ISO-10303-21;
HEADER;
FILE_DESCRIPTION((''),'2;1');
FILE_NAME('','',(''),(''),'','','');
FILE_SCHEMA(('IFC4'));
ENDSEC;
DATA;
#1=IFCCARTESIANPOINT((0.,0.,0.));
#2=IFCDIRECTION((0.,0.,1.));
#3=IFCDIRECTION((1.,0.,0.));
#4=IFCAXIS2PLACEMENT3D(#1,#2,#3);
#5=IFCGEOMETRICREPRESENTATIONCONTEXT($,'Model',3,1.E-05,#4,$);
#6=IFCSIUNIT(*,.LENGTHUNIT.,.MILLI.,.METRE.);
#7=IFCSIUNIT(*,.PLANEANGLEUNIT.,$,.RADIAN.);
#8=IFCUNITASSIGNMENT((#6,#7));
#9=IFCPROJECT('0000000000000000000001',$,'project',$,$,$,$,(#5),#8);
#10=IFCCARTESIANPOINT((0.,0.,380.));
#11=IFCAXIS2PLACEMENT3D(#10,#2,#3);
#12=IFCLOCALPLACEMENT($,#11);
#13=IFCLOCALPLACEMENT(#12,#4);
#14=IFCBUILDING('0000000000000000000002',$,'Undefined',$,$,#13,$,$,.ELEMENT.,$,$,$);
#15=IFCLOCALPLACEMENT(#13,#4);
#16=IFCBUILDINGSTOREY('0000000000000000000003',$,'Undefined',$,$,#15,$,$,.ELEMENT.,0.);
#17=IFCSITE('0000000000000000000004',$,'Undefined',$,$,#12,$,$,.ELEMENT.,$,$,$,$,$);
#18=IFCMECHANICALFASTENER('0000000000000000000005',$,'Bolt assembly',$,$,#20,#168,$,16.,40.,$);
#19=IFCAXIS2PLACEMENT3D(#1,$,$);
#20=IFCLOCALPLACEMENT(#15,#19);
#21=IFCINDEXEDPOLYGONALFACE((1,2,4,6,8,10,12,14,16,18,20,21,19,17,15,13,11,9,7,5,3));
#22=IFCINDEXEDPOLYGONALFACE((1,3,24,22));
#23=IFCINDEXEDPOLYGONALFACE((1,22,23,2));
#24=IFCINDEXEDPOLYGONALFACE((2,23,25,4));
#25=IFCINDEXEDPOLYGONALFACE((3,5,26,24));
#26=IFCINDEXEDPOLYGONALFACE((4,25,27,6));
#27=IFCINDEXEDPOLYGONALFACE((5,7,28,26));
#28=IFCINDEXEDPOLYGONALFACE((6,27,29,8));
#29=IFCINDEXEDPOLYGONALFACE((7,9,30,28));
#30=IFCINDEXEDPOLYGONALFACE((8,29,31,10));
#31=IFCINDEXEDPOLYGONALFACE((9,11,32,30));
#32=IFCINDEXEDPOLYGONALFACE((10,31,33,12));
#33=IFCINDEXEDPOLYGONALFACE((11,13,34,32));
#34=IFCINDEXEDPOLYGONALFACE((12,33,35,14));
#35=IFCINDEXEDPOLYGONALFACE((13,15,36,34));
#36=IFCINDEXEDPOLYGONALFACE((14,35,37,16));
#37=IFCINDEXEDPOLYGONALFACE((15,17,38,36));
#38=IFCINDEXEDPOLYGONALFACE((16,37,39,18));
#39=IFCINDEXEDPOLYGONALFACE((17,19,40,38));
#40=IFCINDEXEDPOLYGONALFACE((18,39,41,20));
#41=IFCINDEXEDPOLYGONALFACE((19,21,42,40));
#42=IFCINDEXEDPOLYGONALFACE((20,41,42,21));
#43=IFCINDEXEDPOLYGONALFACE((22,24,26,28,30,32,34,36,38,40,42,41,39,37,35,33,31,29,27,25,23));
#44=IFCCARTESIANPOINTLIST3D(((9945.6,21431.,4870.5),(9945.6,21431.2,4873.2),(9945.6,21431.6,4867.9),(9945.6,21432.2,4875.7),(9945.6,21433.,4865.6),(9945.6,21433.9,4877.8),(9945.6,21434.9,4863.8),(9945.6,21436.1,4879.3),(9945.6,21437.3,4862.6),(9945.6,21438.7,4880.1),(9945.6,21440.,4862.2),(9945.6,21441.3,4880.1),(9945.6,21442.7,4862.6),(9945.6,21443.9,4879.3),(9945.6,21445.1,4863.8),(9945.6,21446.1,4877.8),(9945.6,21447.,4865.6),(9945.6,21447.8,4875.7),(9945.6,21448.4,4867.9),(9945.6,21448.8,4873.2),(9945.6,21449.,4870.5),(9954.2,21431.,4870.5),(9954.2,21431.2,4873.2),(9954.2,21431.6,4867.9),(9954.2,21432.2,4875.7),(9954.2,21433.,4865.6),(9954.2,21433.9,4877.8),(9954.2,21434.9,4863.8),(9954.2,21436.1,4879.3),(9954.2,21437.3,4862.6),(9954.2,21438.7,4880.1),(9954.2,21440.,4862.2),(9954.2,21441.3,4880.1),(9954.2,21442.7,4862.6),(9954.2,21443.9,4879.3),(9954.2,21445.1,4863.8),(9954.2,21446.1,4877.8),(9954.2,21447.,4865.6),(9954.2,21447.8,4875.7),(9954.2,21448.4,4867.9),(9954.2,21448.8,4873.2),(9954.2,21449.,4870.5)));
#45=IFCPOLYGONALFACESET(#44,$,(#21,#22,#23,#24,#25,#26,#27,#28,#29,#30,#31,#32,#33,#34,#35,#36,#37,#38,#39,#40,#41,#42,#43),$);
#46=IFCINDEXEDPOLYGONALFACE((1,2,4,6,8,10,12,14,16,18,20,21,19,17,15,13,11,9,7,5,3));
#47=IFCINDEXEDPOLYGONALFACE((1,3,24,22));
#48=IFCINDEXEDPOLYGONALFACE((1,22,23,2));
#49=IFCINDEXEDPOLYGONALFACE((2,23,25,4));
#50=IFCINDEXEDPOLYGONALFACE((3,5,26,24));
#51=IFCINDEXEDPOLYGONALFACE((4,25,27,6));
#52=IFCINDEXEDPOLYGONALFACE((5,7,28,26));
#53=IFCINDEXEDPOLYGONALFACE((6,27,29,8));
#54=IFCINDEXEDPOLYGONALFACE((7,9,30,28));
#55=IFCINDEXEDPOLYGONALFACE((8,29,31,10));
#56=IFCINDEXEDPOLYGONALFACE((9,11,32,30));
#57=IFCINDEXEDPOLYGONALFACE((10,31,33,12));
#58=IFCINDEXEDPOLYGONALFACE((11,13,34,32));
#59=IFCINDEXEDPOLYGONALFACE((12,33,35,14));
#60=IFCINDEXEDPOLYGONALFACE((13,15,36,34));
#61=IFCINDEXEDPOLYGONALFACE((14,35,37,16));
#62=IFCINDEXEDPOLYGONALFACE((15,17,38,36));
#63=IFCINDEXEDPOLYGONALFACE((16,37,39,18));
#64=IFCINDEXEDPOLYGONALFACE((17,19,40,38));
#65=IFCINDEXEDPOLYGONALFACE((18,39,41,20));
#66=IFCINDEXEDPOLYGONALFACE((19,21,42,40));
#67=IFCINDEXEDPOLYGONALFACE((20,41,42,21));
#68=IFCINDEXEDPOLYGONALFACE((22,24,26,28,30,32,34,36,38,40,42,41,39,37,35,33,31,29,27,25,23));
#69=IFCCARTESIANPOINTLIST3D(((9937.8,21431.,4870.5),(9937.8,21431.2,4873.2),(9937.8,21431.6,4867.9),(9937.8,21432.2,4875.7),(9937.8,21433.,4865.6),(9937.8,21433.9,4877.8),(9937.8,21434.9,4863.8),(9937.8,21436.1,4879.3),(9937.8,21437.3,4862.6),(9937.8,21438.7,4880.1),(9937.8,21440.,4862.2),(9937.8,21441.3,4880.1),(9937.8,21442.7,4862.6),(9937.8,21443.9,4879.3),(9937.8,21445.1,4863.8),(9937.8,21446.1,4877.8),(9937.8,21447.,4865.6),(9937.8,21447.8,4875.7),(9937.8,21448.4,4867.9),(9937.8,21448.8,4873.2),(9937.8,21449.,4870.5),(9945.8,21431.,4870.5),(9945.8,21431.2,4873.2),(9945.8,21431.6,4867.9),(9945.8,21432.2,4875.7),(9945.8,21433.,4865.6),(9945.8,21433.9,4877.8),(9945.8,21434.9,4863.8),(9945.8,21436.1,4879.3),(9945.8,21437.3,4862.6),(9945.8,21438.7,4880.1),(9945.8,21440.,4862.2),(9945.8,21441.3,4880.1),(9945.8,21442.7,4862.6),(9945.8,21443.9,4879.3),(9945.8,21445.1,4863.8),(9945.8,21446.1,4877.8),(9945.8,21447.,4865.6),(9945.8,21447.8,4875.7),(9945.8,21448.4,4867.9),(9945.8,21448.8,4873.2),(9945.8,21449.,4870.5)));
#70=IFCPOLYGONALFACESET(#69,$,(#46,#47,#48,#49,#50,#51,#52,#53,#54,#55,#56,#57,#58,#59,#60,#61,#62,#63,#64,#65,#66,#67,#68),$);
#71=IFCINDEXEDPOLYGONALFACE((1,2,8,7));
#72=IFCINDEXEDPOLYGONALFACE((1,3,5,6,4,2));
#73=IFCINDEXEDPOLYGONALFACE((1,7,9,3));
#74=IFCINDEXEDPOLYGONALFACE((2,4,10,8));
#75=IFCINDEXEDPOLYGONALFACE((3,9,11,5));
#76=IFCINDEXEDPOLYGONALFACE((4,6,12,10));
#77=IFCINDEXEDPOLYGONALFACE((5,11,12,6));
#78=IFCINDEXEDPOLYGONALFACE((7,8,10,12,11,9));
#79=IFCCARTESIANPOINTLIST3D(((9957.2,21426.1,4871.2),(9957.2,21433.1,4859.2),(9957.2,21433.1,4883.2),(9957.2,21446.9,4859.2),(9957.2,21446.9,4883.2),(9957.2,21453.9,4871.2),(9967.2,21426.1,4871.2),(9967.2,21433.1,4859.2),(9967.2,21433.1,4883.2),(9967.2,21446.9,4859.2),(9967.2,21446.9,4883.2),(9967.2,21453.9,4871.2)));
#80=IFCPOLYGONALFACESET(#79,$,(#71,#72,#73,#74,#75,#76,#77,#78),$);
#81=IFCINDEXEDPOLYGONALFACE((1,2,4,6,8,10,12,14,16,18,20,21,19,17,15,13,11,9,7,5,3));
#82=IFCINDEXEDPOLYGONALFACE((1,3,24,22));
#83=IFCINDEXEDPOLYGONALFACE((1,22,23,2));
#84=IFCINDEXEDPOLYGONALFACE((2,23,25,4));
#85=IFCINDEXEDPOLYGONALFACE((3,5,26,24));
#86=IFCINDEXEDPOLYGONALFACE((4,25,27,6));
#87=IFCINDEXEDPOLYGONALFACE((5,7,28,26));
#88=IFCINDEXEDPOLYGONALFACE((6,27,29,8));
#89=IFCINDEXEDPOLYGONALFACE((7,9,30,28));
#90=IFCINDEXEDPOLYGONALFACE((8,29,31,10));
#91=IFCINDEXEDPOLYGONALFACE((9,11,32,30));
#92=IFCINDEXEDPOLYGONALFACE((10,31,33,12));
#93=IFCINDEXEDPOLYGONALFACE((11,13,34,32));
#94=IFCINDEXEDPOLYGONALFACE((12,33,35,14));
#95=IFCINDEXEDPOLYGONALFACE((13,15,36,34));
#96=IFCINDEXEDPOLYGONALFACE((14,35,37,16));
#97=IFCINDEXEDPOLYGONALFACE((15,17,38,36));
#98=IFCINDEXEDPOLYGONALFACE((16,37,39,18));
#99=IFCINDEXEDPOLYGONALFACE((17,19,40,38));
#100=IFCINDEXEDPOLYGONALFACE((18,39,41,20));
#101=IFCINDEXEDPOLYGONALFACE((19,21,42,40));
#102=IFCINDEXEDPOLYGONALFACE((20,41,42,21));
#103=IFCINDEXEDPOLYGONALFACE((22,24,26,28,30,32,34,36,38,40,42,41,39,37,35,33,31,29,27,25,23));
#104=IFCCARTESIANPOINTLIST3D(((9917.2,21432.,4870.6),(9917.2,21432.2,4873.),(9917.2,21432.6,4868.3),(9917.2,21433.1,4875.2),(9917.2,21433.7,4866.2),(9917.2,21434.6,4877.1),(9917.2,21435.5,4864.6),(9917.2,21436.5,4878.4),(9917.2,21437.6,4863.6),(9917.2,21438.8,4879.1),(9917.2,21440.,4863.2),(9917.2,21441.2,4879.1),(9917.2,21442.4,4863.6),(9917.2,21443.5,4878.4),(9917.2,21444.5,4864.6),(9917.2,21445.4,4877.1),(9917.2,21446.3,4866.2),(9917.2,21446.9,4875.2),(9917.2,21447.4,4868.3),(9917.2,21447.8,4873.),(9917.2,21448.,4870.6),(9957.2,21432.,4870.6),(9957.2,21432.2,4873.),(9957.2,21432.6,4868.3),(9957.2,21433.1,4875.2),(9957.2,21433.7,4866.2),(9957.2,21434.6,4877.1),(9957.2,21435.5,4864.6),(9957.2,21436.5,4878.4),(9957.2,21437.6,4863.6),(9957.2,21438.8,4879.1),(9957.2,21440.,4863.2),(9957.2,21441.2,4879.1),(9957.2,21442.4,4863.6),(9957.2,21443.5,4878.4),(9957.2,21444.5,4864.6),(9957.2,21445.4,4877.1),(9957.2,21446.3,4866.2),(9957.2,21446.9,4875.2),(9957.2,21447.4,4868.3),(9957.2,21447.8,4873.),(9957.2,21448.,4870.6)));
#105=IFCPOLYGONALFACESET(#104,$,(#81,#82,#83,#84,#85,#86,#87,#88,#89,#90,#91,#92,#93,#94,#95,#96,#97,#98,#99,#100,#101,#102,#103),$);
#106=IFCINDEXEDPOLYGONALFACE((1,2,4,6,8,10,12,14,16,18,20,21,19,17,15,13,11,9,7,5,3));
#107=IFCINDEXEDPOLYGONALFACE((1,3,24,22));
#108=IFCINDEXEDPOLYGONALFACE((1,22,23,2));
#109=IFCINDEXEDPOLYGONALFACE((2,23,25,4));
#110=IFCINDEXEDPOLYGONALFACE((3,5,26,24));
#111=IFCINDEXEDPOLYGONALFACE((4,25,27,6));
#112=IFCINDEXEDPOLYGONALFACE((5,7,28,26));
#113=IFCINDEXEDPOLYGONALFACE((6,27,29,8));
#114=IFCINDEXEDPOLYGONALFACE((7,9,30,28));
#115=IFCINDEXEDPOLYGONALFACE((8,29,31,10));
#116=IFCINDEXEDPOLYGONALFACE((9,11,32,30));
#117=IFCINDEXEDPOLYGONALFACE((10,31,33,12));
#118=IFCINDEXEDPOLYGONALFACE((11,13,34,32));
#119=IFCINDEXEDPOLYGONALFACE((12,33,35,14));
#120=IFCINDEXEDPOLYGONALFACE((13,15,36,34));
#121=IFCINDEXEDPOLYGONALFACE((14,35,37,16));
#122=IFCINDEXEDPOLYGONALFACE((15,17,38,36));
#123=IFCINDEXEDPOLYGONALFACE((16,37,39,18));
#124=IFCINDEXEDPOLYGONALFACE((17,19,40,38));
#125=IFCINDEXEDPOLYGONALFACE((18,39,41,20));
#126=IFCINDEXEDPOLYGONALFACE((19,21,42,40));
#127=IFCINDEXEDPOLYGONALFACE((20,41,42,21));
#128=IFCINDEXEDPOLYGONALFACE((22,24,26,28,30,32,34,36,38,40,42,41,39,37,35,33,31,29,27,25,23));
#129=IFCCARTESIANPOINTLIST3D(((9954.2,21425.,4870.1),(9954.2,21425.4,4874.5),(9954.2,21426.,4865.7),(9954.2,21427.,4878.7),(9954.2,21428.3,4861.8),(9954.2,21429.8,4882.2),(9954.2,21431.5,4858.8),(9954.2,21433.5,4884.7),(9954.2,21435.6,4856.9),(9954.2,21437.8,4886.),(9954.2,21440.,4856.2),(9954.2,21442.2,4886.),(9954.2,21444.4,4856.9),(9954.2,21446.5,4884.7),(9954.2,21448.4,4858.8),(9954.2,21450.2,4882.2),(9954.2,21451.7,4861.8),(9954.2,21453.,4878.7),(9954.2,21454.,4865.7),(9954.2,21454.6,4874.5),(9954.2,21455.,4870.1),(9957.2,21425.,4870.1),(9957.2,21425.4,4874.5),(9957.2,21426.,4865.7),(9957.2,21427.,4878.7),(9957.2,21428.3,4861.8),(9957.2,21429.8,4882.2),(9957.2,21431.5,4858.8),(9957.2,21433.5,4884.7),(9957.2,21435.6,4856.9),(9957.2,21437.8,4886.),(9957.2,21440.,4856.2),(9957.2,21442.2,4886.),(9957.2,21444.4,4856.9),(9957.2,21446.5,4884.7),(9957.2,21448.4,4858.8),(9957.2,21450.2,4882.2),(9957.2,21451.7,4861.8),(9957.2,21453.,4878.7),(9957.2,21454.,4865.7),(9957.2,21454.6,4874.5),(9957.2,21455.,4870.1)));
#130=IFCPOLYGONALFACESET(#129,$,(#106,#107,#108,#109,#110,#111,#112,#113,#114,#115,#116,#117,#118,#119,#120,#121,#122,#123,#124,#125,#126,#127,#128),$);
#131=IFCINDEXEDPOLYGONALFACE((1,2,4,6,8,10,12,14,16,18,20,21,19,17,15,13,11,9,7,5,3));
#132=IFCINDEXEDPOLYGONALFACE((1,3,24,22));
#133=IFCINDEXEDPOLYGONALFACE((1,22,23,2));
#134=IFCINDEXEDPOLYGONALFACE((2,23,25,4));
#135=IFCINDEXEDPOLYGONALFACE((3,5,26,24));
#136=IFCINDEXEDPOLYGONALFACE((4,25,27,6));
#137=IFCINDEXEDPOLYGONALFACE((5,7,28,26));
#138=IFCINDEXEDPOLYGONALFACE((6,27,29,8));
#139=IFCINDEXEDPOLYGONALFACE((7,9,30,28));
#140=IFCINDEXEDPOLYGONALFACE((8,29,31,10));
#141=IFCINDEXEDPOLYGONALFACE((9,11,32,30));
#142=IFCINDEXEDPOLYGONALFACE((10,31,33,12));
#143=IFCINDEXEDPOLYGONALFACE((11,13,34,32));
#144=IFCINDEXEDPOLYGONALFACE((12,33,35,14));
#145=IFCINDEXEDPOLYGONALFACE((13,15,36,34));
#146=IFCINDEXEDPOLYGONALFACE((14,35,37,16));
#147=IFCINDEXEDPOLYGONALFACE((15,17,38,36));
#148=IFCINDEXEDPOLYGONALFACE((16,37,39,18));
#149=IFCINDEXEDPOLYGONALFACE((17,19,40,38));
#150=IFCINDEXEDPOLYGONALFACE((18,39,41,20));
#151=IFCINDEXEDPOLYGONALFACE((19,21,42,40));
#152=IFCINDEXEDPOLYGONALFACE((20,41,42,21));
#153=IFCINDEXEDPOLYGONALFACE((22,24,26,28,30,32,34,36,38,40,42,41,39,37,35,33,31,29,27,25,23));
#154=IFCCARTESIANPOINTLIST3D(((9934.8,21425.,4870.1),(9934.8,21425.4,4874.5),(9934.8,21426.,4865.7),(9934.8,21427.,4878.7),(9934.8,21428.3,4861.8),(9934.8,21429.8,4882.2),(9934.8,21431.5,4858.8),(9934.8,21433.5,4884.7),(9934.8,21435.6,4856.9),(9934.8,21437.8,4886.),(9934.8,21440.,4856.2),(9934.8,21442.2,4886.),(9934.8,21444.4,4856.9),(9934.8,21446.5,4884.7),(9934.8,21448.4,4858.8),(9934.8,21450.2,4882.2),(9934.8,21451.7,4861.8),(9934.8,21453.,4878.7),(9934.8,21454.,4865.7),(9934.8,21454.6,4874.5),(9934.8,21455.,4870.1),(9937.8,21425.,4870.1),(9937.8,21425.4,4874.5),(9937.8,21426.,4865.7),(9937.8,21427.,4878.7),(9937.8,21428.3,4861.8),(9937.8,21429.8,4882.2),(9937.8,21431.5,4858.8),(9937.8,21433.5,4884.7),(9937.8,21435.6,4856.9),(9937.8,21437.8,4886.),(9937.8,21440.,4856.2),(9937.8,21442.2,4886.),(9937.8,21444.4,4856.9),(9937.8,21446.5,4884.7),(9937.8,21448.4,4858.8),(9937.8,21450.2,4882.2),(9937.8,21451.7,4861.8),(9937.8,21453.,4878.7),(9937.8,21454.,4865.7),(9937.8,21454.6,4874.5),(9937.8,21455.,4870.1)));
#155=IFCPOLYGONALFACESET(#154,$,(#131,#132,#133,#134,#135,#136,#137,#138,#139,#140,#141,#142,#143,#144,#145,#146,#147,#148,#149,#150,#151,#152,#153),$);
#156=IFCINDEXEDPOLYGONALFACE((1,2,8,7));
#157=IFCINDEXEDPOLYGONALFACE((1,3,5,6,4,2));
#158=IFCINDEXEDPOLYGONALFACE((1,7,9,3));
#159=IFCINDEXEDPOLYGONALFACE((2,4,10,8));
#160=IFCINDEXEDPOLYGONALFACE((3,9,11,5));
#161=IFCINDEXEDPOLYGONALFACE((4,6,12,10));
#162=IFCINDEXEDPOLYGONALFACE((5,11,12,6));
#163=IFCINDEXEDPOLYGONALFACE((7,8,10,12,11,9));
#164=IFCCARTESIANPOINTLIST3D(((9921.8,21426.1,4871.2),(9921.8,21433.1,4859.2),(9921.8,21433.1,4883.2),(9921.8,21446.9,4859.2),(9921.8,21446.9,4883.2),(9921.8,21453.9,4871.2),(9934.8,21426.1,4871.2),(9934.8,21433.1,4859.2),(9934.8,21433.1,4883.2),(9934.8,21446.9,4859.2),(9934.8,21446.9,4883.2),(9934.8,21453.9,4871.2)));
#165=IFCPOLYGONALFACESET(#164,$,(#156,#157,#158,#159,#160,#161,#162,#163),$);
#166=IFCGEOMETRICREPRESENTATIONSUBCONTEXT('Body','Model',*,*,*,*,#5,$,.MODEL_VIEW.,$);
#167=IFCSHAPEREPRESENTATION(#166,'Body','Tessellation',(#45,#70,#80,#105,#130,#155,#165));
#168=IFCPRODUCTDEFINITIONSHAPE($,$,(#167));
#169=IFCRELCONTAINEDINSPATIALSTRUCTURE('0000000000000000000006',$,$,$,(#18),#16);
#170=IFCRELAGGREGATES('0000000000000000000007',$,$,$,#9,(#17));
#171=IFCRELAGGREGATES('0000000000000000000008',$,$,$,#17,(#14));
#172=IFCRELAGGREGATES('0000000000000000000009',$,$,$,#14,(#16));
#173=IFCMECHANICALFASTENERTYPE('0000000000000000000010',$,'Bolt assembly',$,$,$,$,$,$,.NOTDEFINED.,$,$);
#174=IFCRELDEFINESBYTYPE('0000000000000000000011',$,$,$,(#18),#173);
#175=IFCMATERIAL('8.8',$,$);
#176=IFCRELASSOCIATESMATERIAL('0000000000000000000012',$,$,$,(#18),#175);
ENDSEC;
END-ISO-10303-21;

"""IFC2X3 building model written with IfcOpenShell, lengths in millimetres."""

from ifc_helpers import new_model, si_unit, frame, origin_with_axes, origin_2d_with_axis, place, context, subcontext, project, spatial, polyline, circle, outline, extrude, source, transform, mapped, material, type_object, element, save


model = new_model("IFC2X3")

# Units and contexts
model_context = context("Model", 3, precision=1e-05, world=origin_with_axes())
body_context = subcontext(model_context, "Body", "Model", "MODEL_VIEW")
ifc_project = project(units=[si_unit("LENGTHUNIT", "METRE", prefix="MILLI"), si_unit("PLANEANGLEUNIT", "RADIAN")], contexts=[model_context])

# Site, building, storey
site_placement = place(None, frame((0.0, 0.0, 380.0), z_axis=(0.0, 0.0, 1.0), x_axis=(1.0, 0.0, 0.0)))
site = spatial("IfcSite", under=ifc_project, at=site_placement, Name="Undefined", CompositionType="ELEMENT")
building_placement = place(site_placement, origin_with_axes())
building = spatial("IfcBuilding", under=site, at=building_placement, Name="Undefined", CompositionType="ELEMENT")
storey_placement = place(building_placement, origin_with_axes())
storey = spatial("IfcBuildingStorey", under=building, at=storey_placement, Name="Undefined", CompositionType="ELEMENT", Elevation=0.0)

# Mechanical fastener
ifc_material_1 = material(Name="8.8")
mechanical_fastener_type = type_object("IfcMechanicalFastenerType", Name="Bolt assembly")
shared_shape_1 = source(origin_with_axes(), body_context, "Body", "SweptSolid", [
    extrude(circle(Radius=9.0, at=origin_2d_with_axis()), frame((0.0, -8.4, 0.0), z_axis=(0.0, 1.0, 0.0), x_axis=(1.0, 0.0, 0.0)), (0.0, 0.0, 1.0), 8.5),
    extrude(circle(Radius=9.0, at=origin_2d_with_axis()), frame((0.0, -0.1, 0.0), z_axis=(0.0, 1.0, 0.0), x_axis=(1.0, 0.0, 0.0)), (0.0, 0.0, 1.0), 8.1),
    extrude(outline(polyline([(12.0, -6.9), (12.0, 6.9), (0.0, 13.9), (-12.0, 6.9), (-12.0, -6.9), (0.0, -13.9), (12.0, -6.9)])), frame((0.0, -21.5, 0.0), z_axis=(0.0, 1.0, 0.0), x_axis=(1.0, 0.0, 0.0)), (0.0, 0.0, 1.0), 10.0),
    extrude(circle(Radius=8.0, at=origin_2d_with_axis()), frame((0.0, -11.5, 0.0), z_axis=(0.0, 1.0, 0.0), x_axis=(1.0, 0.0, 0.0)), (0.0, 0.0, 1.0), 40.0),
    extrude(circle(Radius=15.0, at=origin_2d_with_axis()), frame((0.0, -11.5, 0.0), z_axis=(0.0, 1.0, 0.0), x_axis=(1.0, 0.0, 0.0)), (0.0, 0.0, 1.0), 3.0),
    extrude(circle(Radius=15.0, at=origin_2d_with_axis()), frame((0.0, 8.0, 0.0), z_axis=(0.0, 1.0, 0.0), x_axis=(1.0, 0.0, 0.0)), (0.0, 0.0, 1.0), 3.0),
    extrude(outline(polyline([(12.0, -6.9), (12.0, 6.9), (0.0, 13.9), (-12.0, 6.9), (-12.0, -6.9), (0.0, -13.9), (12.0, -6.9)])), frame((0.0, 11.0, 0.0), z_axis=(0.0, 1.0, 0.0), x_axis=(1.0, 0.0, 0.0)), (0.0, 0.0, 1.0), 13.0),
])
for number, where, z_axis, x_axis, name in (
    (1, (9945.8, 21402.5, 4951.2), (0.0, 1.0, 0.0), (0.0, 0.0, -1.0), "Bolt assembly"),
):
    element("IfcMechanicalFastener", number, at=place(storey_placement, frame(where, z_axis=z_axis, x_axis=x_axis)), inside=storey, type_object=mechanical_fastener_type, material=ifc_material_1, Name=name, NominalDiameter=16.0, NominalLength=40.0, context=body_context, shape_type="MappedRepresentation", body=[
        mapped(shared_shape_1, transform((80.0, 0.0, 37.5))),
    ])

save(model, "model.ifc")
